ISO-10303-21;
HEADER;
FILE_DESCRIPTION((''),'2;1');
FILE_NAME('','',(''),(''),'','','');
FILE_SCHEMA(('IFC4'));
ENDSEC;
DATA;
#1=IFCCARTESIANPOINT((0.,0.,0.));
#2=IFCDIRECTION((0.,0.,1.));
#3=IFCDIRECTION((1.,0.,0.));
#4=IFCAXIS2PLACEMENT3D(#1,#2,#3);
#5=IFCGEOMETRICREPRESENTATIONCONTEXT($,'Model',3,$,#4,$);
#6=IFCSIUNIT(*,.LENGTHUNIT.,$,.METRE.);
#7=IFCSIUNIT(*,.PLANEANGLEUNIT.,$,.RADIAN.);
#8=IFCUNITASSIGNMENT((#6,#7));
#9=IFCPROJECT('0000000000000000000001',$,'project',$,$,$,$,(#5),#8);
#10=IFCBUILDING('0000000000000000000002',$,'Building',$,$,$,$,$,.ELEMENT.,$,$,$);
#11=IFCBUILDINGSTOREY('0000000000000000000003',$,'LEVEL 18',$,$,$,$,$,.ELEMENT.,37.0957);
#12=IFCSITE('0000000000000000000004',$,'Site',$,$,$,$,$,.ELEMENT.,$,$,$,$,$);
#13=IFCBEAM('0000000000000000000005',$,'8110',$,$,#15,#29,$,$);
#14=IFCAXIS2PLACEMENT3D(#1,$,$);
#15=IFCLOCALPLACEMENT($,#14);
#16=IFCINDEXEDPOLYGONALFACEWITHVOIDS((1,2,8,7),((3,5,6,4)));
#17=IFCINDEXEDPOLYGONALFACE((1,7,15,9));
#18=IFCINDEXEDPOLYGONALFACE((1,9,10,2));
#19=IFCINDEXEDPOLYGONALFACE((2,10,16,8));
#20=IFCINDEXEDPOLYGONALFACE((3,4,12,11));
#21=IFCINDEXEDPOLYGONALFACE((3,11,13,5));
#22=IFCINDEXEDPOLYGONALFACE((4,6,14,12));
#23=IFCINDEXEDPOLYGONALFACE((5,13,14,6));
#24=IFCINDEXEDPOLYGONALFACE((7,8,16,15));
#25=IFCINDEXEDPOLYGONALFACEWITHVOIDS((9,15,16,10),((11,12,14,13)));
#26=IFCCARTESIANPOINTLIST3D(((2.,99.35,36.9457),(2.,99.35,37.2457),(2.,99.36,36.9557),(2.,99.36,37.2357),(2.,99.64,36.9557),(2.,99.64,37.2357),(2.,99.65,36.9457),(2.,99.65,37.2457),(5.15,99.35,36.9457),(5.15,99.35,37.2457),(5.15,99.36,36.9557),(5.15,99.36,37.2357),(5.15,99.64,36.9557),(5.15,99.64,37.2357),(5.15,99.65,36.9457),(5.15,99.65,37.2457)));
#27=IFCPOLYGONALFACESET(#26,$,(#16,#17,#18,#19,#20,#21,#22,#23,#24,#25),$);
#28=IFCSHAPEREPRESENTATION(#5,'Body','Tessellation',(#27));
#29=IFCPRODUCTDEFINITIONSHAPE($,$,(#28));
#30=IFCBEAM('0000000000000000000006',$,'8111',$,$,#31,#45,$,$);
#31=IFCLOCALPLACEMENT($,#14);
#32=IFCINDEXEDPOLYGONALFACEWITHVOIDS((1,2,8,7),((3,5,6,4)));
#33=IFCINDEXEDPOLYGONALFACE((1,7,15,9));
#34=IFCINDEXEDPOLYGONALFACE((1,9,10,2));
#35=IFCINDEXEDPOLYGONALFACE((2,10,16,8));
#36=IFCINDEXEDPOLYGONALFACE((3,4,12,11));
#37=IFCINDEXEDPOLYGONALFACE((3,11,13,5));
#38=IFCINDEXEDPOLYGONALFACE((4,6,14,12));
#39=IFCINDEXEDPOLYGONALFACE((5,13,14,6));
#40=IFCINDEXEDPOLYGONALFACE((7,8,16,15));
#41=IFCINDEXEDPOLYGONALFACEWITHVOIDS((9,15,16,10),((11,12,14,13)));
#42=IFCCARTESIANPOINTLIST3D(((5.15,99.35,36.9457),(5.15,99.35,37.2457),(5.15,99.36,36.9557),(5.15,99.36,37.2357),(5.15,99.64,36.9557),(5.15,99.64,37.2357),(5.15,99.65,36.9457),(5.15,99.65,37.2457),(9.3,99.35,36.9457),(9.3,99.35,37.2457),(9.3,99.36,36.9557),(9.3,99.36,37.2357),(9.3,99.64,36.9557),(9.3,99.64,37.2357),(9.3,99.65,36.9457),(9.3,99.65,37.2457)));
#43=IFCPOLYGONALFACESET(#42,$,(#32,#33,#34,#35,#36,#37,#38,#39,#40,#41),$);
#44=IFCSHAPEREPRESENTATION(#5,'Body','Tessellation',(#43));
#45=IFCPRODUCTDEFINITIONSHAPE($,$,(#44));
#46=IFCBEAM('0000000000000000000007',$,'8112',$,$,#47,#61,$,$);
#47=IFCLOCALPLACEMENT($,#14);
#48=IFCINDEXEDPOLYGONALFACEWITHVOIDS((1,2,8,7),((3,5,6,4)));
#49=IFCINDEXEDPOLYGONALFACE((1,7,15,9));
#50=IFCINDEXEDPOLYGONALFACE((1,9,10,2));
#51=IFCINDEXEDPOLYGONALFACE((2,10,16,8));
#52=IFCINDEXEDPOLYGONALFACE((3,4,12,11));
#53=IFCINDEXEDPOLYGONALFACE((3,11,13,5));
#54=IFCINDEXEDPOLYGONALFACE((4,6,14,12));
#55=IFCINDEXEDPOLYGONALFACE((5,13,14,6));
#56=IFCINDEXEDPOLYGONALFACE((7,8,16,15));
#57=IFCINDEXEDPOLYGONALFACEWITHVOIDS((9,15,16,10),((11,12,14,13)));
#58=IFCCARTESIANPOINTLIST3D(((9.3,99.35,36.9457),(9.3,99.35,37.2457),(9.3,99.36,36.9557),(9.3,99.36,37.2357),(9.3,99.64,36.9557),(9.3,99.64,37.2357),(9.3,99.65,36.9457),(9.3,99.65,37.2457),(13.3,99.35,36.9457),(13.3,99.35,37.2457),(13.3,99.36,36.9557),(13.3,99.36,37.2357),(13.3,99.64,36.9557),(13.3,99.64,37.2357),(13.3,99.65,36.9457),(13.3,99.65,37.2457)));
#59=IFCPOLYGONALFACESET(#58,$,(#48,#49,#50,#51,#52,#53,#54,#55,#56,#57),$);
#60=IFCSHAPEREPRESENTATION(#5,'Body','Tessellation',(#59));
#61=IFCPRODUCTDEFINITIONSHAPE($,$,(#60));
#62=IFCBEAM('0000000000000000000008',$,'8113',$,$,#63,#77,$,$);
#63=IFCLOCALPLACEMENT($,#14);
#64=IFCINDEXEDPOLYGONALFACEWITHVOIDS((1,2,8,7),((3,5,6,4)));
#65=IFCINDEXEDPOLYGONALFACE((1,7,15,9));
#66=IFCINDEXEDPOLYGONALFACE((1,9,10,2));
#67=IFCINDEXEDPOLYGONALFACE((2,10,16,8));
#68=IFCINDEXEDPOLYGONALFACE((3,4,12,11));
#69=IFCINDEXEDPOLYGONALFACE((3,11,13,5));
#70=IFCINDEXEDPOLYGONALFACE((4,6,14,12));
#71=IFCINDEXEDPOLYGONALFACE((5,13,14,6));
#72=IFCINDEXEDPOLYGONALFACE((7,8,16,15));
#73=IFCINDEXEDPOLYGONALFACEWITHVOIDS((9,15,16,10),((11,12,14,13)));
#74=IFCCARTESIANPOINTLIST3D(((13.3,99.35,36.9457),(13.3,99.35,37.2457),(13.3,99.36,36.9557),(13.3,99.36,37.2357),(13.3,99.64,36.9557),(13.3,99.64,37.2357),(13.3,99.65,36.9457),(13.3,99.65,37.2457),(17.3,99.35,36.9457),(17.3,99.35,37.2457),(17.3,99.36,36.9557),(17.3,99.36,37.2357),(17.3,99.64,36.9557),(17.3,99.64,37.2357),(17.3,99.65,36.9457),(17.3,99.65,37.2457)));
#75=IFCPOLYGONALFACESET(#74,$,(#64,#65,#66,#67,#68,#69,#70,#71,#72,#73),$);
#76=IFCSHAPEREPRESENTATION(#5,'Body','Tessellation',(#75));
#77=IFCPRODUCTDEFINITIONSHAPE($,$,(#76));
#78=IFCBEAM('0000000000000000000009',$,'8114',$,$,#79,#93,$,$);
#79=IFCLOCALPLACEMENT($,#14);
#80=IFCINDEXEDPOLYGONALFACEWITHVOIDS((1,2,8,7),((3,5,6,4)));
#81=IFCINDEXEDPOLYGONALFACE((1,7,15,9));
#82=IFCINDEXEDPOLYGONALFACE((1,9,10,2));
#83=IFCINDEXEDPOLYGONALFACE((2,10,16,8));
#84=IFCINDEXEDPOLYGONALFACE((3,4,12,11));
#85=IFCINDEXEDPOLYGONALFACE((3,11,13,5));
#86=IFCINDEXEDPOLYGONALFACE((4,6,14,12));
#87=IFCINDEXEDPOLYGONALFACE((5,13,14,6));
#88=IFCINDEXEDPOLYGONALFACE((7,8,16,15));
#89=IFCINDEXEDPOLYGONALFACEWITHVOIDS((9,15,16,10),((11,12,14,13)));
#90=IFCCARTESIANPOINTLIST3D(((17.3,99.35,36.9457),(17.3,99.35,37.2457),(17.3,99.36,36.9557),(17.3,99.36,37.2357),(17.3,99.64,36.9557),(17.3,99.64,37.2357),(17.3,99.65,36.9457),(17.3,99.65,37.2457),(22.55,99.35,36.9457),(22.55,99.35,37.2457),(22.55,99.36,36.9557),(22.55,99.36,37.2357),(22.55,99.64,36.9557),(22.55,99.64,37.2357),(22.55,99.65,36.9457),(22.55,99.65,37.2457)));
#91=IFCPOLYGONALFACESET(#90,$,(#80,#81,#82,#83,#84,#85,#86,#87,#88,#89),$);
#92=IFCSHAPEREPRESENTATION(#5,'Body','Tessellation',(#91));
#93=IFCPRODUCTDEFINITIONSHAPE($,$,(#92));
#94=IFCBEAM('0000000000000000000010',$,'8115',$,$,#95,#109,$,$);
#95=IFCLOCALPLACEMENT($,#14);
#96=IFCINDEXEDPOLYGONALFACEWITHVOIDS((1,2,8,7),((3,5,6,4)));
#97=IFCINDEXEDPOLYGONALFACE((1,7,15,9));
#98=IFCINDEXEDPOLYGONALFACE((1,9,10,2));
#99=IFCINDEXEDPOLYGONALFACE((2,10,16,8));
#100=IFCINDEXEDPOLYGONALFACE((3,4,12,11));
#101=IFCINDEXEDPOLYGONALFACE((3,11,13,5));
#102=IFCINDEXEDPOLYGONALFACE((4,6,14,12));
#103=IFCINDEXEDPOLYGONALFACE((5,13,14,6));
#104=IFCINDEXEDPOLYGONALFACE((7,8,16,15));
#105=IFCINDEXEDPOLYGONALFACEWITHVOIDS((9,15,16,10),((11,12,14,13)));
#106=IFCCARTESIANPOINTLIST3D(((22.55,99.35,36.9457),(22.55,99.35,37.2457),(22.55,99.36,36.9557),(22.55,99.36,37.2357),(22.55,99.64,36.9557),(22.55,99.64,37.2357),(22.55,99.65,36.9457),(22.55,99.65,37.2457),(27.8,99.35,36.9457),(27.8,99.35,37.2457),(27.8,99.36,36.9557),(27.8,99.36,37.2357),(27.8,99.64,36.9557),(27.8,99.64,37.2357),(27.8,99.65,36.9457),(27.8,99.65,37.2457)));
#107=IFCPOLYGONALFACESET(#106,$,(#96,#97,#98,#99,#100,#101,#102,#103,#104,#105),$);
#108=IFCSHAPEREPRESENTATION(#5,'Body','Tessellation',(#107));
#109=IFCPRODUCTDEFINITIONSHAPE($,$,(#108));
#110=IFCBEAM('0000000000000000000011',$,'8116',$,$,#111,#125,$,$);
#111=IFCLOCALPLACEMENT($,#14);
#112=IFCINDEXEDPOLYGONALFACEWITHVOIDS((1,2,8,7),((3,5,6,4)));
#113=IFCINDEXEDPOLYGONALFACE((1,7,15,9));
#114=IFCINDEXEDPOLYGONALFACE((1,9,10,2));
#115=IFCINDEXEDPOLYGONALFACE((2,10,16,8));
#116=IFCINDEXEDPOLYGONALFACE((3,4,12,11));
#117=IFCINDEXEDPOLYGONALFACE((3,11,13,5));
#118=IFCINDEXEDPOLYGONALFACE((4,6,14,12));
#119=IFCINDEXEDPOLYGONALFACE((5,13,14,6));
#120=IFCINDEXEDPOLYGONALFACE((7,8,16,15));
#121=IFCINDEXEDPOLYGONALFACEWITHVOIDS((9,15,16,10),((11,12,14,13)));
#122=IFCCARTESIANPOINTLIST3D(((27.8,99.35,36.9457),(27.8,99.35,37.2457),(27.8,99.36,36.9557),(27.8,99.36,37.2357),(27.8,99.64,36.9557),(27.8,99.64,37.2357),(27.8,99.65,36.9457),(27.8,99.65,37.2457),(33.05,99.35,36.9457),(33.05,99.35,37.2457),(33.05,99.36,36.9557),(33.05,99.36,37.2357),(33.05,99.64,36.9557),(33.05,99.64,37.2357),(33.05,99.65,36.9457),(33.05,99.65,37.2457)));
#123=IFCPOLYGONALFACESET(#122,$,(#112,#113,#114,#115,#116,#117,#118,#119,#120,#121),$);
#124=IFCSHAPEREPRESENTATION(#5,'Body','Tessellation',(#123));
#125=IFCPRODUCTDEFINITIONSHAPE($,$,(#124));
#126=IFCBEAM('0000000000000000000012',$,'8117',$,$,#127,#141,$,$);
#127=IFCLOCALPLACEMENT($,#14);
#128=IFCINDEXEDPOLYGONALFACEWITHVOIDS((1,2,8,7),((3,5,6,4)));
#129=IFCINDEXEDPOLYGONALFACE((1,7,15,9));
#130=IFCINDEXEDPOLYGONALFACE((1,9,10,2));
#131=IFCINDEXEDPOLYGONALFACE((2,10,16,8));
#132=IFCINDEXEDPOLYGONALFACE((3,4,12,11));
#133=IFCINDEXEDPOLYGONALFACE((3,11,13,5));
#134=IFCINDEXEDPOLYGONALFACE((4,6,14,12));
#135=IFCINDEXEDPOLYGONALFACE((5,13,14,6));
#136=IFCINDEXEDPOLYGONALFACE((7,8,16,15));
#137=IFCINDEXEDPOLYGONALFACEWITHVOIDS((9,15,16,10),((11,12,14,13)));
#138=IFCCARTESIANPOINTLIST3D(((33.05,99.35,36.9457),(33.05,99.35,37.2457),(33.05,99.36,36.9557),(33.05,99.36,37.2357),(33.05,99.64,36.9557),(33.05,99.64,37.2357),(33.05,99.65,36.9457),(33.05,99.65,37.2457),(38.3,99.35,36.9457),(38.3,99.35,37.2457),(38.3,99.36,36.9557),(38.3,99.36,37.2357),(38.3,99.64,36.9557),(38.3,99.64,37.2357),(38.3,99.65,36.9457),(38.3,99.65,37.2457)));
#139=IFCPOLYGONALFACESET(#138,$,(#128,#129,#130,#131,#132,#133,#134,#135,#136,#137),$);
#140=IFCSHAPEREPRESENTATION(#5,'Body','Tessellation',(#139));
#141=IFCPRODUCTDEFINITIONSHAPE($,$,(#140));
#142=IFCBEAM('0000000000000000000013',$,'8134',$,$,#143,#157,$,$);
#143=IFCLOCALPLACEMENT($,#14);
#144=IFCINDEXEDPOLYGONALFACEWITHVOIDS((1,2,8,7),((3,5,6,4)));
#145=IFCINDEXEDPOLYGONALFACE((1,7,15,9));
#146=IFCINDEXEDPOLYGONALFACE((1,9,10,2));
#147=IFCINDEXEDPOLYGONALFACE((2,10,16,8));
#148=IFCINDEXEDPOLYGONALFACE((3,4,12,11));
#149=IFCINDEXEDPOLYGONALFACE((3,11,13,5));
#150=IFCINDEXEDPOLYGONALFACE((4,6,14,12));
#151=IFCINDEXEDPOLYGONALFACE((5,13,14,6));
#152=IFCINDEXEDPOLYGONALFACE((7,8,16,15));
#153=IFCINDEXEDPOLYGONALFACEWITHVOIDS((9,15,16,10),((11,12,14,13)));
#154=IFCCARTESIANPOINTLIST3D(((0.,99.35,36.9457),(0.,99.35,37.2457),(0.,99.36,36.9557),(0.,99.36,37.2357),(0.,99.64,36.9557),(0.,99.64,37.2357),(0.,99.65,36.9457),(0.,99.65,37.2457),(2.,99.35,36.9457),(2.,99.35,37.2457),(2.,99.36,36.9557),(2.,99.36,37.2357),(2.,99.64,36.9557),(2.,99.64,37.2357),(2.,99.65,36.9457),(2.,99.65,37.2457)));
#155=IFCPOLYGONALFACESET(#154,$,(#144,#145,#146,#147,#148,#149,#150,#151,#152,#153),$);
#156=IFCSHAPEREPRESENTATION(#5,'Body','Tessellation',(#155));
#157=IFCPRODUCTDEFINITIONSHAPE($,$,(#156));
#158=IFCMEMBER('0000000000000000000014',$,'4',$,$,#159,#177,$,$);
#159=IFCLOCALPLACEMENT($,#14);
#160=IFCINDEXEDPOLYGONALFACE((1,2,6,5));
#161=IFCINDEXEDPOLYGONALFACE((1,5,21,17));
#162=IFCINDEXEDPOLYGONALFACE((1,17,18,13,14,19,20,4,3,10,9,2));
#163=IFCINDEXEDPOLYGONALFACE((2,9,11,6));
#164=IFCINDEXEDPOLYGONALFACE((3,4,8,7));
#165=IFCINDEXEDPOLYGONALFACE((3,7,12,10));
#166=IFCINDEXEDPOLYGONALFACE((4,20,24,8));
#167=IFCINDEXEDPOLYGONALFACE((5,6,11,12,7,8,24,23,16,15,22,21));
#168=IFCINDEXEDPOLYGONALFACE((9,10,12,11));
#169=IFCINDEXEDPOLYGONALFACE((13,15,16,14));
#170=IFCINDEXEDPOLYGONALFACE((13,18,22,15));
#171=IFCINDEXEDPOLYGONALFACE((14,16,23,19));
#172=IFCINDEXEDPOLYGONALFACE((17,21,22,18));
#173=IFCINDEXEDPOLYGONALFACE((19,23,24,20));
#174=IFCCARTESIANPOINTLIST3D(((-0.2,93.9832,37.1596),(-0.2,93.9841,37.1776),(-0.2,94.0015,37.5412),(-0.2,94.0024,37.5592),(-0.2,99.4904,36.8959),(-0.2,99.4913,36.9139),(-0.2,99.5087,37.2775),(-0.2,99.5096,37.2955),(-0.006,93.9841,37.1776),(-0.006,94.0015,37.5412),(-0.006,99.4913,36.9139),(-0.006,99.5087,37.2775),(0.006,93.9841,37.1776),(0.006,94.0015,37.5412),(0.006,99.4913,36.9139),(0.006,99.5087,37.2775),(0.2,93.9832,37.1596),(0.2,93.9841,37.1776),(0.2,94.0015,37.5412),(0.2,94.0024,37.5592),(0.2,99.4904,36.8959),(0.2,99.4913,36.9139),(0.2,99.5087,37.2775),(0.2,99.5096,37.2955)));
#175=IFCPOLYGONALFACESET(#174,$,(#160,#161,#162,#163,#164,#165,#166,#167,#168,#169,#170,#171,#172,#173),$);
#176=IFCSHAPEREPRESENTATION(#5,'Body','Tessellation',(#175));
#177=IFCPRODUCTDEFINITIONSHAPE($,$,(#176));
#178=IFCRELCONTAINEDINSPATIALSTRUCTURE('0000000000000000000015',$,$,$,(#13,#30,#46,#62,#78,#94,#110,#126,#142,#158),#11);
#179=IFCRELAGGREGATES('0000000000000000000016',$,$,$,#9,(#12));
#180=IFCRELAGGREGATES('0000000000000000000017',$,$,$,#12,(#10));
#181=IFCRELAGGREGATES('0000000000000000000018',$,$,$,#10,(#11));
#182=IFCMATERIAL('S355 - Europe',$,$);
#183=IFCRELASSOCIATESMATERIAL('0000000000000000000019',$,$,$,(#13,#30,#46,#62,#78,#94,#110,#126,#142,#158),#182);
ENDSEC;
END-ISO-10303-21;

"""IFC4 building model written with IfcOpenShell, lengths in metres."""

from ifc_helpers import new_model, si_unit, frame, origin_with_axes, origin_2d_with_axis, place, context, project, spatial, hollow_rectangle, i_section, extrude, material, material_profile, profile_set, profile_usage, element, save


model = new_model("IFC4")

# Units and contexts
model_context = context("Model", 3, world=origin_with_axes())
ifc_project = project(units=[si_unit("LENGTHUNIT", "METRE"), si_unit("PLANEANGLEUNIT", "RADIAN")], contexts=[model_context])

# Site, building, storey
site = spatial("IfcSite", under=ifc_project, Name="Site", CompositionType="ELEMENT")
building = spatial("IfcBuilding", under=site, Name="Building", CompositionType="ELEMENT")
storey = spatial("IfcBuildingStorey", under=building, Name="LEVEL 18", CompositionType="ELEMENT", Elevation=37.0957)

# Beams
ifc_material = material(Name="S355 - Europe")
ifc_material_profile_1 = material_profile(ifc_material, hollow_rectangle(XDim=0.3, YDim=0.3, WallThickness=0.01, at=origin_2d_with_axis()))
ifc_profile_set_1 = profile_set([ifc_material_profile_1])
ifc_profile_usage_1 = profile_usage(ifc_profile_set_1, cardinal=10)
beam_1_placement = place(None, frame((5.15, 99.5, 37.0957), z_axis=(-1.0, 0.0, 0.0), x_axis=(0.0, -1.0, 0.0)))
element("IfcBeam", 1, at=beam_1_placement, inside=storey, material=ifc_profile_usage_1, Name="8110", context=model_context, shape_type="SweptSolid", body=[
    extrude(hollow_rectangle(XDim=0.3, YDim=0.3, WallThickness=0.01, at=origin_2d_with_axis()), origin_with_axes(), (0.0, 0.0, 1.0), 3.15),
])
ifc_material_profile_2 = material_profile(ifc_material, hollow_rectangle(XDim=0.3, YDim=0.3, WallThickness=0.01, at=origin_2d_with_axis()))
ifc_profile_set_2 = profile_set([ifc_material_profile_2])
ifc_profile_usage_2 = profile_usage(ifc_profile_set_2, cardinal=10)
beam_2_placement = place(None, frame((9.3, 99.5, 37.0957), z_axis=(-1.0, 0.0, 0.0), x_axis=(0.0, -1.0, 0.0)))
element("IfcBeam", 2, at=beam_2_placement, inside=storey, material=ifc_profile_usage_2, Name="8111", context=model_context, shape_type="SweptSolid", body=[
    extrude(hollow_rectangle(XDim=0.3, YDim=0.3, WallThickness=0.01, at=origin_2d_with_axis()), origin_with_axes(), (0.0, 0.0, 1.0), 4.15),
])
ifc_material_profile_3 = material_profile(ifc_material, hollow_rectangle(XDim=0.3, YDim=0.3, WallThickness=0.01, at=origin_2d_with_axis()))
ifc_profile_set_3 = profile_set([ifc_material_profile_3])
ifc_profile_usage_3 = profile_usage(ifc_profile_set_3, cardinal=10)
beam_3_placement = place(None, frame((13.3, 99.5, 37.0957), z_axis=(-1.0, 0.0, 0.0), x_axis=(0.0, -1.0, 0.0)))
element("IfcBeam", 3, at=beam_3_placement, inside=storey, material=ifc_profile_usage_3, Name="8112", context=model_context, shape_type="SweptSolid", body=[
    extrude(hollow_rectangle(XDim=0.3, YDim=0.3, WallThickness=0.01, at=origin_2d_with_axis()), origin_with_axes(), (0.0, 0.0, 1.0), 4.0),
])
ifc_material_profile_4 = material_profile(ifc_material, hollow_rectangle(XDim=0.3, YDim=0.3, WallThickness=0.01, at=origin_2d_with_axis()))
ifc_profile_set_4 = profile_set([ifc_material_profile_4])
ifc_profile_usage_4 = profile_usage(ifc_profile_set_4, cardinal=10)
beam_4_placement = place(None, frame((17.3, 99.5, 37.0957), z_axis=(-1.0, 0.0, 0.0), x_axis=(0.0, -1.0, 0.0)))
element("IfcBeam", 4, at=beam_4_placement, inside=storey, material=ifc_profile_usage_4, Name="8113", context=model_context, shape_type="SweptSolid", body=[
    extrude(hollow_rectangle(XDim=0.3, YDim=0.3, WallThickness=0.01, at=origin_2d_with_axis()), origin_with_axes(), (0.0, 0.0, 1.0), 4.0),
])
ifc_material_profile_5 = material_profile(ifc_material, hollow_rectangle(XDim=0.3, YDim=0.3, WallThickness=0.01, at=origin_2d_with_axis()))
ifc_profile_set_5 = profile_set([ifc_material_profile_5])
ifc_profile_usage_5 = profile_usage(ifc_profile_set_5, cardinal=10)
beam_5_placement = place(None, frame((22.55, 99.5, 37.0957), z_axis=(-1.0, 0.0, 0.0), x_axis=(0.0, -1.0, 0.0)))
element("IfcBeam", 5, at=beam_5_placement, inside=storey, material=ifc_profile_usage_5, Name="8114", context=model_context, shape_type="SweptSolid", body=[
    extrude(hollow_rectangle(XDim=0.3, YDim=0.3, WallThickness=0.01, at=origin_2d_with_axis()), origin_with_axes(), (0.0, 0.0, 1.0), 5.25),
])
ifc_material_profile_6 = material_profile(ifc_material, hollow_rectangle(XDim=0.3, YDim=0.3, WallThickness=0.01, at=origin_2d_with_axis()))
ifc_profile_set_6 = profile_set([ifc_material_profile_6])
ifc_profile_usage_6 = profile_usage(ifc_profile_set_6, cardinal=10)
beam_6_placement = place(None, frame((27.8, 99.5, 37.0957), z_axis=(-1.0, 0.0, 0.0), x_axis=(0.0, -1.0, 0.0)))
element("IfcBeam", 6, at=beam_6_placement, inside=storey, material=ifc_profile_usage_6, Name="8115", context=model_context, shape_type="SweptSolid", body=[
    extrude(hollow_rectangle(XDim=0.3, YDim=0.3, WallThickness=0.01, at=origin_2d_with_axis()), origin_with_axes(), (0.0, 0.0, 1.0), 5.25),
])
ifc_material_profile_7 = material_profile(ifc_material, hollow_rectangle(XDim=0.3, YDim=0.3, WallThickness=0.01, at=origin_2d_with_axis()))
ifc_profile_set_7 = profile_set([ifc_material_profile_7])
ifc_profile_usage_7 = profile_usage(ifc_profile_set_7, cardinal=10)
beam_7_placement = place(None, frame((33.05, 99.5, 37.0957), z_axis=(-1.0, 0.0, 0.0), x_axis=(0.0, -1.0, 0.0)))
element("IfcBeam", 7, at=beam_7_placement, inside=storey, material=ifc_profile_usage_7, Name="8116", context=model_context, shape_type="SweptSolid", body=[
    extrude(hollow_rectangle(XDim=0.3, YDim=0.3, WallThickness=0.01, at=origin_2d_with_axis()), origin_with_axes(), (0.0, 0.0, 1.0), 5.25),
])
ifc_material_profile_8 = material_profile(ifc_material, hollow_rectangle(XDim=0.3, YDim=0.3, WallThickness=0.01, at=origin_2d_with_axis()))
ifc_profile_set_8 = profile_set([ifc_material_profile_8])
ifc_profile_usage_8 = profile_usage(ifc_profile_set_8, cardinal=10)
beam_8_placement = place(None, frame((38.3, 99.5, 37.0957), z_axis=(-1.0, 0.0, 0.0), x_axis=(0.0, -1.0, 0.0)))
element("IfcBeam", 8, at=beam_8_placement, inside=storey, material=ifc_profile_usage_8, Name="8117", context=model_context, shape_type="SweptSolid", body=[
    extrude(hollow_rectangle(XDim=0.3, YDim=0.3, WallThickness=0.01, at=origin_2d_with_axis()), origin_with_axes(), (0.0, 0.0, 1.0), 5.25),
])
ifc_material_profile_9 = material_profile(ifc_material, hollow_rectangle(XDim=0.3, YDim=0.3, WallThickness=0.01, at=origin_2d_with_axis()))
ifc_profile_set_9 = profile_set([ifc_material_profile_9])
ifc_profile_usage_9 = profile_usage(ifc_profile_set_9, cardinal=10)
beam_9_placement = place(None, frame((2.0, 99.5, 37.0957), z_axis=(-1.0, 0.0, 0.0), x_axis=(0.0, -1.0, 0.0)))
element("IfcBeam", 9, at=beam_9_placement, inside=storey, material=ifc_profile_usage_9, Name="8134", context=model_context, shape_type="SweptSolid", body=[
    extrude(hollow_rectangle(XDim=0.3, YDim=0.3, WallThickness=0.01, at=origin_2d_with_axis()), origin_with_axes(), (0.0, 0.0, 1.0), 2.0),
])

# Member
ifc_material_profile_10 = material_profile(ifc_material, i_section(OverallWidth=0.4, OverallDepth=0.4, WebThickness=0.012, FlangeThickness=0.018, at=origin_2d_with_axis()))
ifc_profile_set_10 = profile_set([ifc_material_profile_10])
ifc_profile_usage_10 = profile_usage(ifc_profile_set_10, cardinal=10)
member_1_placement = place(None, frame((0.0, 99.5, 37.0957), z_axis=(0.0, -0.998856, 0.047828), x_axis=(1.0, 0.0, 0.0)))
element("IfcMember", 10, at=member_1_placement, inside=storey, material=ifc_profile_usage_10, Name="4", context=model_context, shape_type="SweptSolid", body=[
    extrude(i_section(OverallWidth=0.4, OverallDepth=0.4, WebThickness=0.012, FlangeThickness=0.018, at=origin_2d_with_axis()), origin_with_axes(), (0.0, 0.0, 1.0), 5.5135),
])

save(model, "model.ifc")
